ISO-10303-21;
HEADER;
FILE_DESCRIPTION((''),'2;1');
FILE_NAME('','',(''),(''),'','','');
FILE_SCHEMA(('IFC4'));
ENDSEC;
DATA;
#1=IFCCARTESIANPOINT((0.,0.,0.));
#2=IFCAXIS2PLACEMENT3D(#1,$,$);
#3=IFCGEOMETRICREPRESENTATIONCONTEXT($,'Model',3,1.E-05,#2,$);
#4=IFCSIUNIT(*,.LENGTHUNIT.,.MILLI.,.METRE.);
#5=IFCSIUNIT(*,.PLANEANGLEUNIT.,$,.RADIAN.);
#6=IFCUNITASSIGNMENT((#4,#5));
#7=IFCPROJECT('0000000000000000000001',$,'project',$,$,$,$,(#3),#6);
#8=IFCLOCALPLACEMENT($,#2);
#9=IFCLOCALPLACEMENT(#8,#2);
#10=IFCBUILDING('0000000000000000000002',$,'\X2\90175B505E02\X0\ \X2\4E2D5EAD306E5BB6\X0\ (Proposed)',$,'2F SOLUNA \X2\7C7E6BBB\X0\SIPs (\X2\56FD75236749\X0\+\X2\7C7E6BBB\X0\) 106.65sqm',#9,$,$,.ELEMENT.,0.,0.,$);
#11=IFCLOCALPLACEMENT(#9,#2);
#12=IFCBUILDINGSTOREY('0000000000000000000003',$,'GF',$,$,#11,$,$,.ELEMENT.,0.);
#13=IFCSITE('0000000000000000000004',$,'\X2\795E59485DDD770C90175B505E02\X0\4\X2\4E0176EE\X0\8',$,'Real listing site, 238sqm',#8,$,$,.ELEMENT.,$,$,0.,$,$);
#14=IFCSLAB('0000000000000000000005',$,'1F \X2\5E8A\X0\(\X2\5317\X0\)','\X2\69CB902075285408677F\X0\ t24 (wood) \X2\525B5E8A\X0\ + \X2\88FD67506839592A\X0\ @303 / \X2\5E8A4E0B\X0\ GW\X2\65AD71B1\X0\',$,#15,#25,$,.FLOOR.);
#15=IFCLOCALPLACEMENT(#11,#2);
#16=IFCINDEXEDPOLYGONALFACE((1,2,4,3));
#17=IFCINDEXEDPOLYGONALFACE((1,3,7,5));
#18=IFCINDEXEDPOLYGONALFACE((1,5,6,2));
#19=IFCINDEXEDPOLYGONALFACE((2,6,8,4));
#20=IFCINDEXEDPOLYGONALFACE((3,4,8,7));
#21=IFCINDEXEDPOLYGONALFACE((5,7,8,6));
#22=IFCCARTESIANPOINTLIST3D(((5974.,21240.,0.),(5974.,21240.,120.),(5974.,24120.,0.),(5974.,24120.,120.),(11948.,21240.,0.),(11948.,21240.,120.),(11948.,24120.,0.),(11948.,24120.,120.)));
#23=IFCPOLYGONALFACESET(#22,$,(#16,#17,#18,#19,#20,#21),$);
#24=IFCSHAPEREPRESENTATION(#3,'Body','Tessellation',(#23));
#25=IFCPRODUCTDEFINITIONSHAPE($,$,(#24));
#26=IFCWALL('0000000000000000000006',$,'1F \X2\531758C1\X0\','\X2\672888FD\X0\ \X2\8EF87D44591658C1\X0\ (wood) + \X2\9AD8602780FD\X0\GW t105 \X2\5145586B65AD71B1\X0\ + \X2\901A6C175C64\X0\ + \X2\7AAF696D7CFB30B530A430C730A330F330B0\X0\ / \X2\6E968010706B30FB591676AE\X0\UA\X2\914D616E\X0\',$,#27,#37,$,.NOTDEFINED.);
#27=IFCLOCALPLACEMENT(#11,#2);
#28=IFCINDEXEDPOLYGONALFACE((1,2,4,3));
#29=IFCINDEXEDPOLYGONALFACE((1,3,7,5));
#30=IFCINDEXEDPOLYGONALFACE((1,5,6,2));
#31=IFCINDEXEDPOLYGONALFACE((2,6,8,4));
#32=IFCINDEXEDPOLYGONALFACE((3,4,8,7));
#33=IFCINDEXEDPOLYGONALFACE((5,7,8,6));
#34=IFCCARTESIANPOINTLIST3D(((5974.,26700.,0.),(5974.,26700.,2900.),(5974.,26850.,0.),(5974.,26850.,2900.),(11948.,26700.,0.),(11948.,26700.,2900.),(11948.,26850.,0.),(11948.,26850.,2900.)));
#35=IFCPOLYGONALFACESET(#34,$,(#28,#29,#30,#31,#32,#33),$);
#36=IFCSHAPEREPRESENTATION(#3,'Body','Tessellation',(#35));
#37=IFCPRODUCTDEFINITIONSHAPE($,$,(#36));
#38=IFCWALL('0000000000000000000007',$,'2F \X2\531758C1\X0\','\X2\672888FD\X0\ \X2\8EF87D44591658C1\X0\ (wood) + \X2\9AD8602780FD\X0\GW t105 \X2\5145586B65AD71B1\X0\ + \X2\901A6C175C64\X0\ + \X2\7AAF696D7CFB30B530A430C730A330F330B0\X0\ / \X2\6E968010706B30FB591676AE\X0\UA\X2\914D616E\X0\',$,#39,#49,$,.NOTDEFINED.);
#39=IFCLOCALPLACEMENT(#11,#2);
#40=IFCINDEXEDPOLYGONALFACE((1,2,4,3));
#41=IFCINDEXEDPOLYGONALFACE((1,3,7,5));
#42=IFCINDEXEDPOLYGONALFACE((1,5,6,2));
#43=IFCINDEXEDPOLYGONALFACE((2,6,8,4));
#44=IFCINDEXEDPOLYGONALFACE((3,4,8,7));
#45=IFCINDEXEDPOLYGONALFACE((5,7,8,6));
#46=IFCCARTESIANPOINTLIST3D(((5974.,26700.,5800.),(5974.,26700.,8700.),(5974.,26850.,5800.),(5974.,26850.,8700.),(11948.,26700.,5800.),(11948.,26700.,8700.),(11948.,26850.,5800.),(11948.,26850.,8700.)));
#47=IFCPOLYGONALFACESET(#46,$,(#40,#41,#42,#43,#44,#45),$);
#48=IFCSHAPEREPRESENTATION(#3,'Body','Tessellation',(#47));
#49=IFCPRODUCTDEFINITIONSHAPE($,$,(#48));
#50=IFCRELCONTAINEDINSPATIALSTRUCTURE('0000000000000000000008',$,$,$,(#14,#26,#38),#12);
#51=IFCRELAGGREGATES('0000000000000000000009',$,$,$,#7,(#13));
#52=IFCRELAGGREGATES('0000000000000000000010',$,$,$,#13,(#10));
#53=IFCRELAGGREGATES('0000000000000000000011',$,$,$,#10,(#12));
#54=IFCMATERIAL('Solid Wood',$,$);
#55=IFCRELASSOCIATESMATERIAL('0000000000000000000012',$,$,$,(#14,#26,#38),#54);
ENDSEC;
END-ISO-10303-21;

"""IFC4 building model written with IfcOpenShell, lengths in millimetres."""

from ifc_helpers import new_model, si_unit, frame, frame_2d, origin, place, context, project, spatial, rectangle, extrude, material, element, save


model = new_model("IFC4")

# Units and contexts
model_context = context("Model", 3, precision=1e-05, world=origin())
ifc_project = project(units=[si_unit("LENGTHUNIT", "METRE", prefix="MILLI"), si_unit("PLANEANGLEUNIT", "RADIAN")], contexts=[model_context])

# Site, building, storey
site_placement = place(None, origin())
site = spatial("IfcSite", under=ifc_project, at=site_placement, Name="神奈川県逗子市4丁目8", ObjectType="Real listing site, 238sqm", CompositionType="ELEMENT", RefElevation=0.0)
building_placement = place(site_placement, origin())
building = spatial("IfcBuilding", under=site, at=building_placement, Name="逗子市 中庭の家 (Proposed)", ObjectType="2F SOLUNA 籾殻SIPs (国産杉+籾殻) 106.65sqm", CompositionType="ELEMENT", ElevationOfRefHeight=0.0, ElevationOfTerrain=0.0)
storey_placement = place(building_placement, origin())
storey = spatial("IfcBuildingStorey", under=building, at=storey_placement, Name="GF", CompositionType="ELEMENT", Elevation=0.0)

# Slab
ifc_material_1 = material(Name="Solid Wood")
slab_1_placement = place(storey_placement, frame((2987.0, 10620.0, 0.0)))
element("IfcSlab", 1, at=slab_1_placement, inside=storey, material=ifc_material_1, Name="1F 床(北)", Description="構造用合板 t24 (wood) 剛床 + 製材根太 @303 / 床下 GW断熱", PredefinedType="FLOOR", context=model_context, shape_type="SweptSolid", body=[
    extrude(rectangle(XDim=5974.0, YDim=2880.0, at=frame_2d((2987.0, 1440.0))), frame((2987.0, 10620.0, 0.0)), (0.0, 0.0, 1.0), 120.0),
])

# Wall
wall_1_placement = place(storey_placement, frame((2987.0, 13350.0, 0.0)))
element("IfcWall", 2, at=wall_1_placement, inside=storey, material=ifc_material_1, Name="1F 北壁", Description="木製 軸組外壁 (wood) + 高性能GW t105 充填断熱 + 通気層 + 窯業系サイディング / 準耐火・外皮UA配慮", PredefinedType="NOTDEFINED", context=model_context, shape_type="SweptSolid", body=[
    extrude(rectangle(XDim=5974.0, YDim=150.0, at=frame_2d((2987.0, 75.0))), frame((2987.0, 13350.0, 0.0)), (0.0, 0.0, 1.0), 2900.0),
])

# Wall
wall_2_placement = place(storey_placement, frame((2987.0, 13350.0, 2900.0)))
element("IfcWall", 3, at=wall_2_placement, inside=storey, material=ifc_material_1, Name="2F 北壁", Description="木製 軸組外壁 (wood) + 高性能GW t105 充填断熱 + 通気層 + 窯業系サイディング / 準耐火・外皮UA配慮", PredefinedType="NOTDEFINED", context=model_context, shape_type="SweptSolid", body=[
    extrude(rectangle(XDim=5974.0, YDim=150.0, at=frame_2d((2987.0, 75.0))), frame((2987.0, 13350.0, 2900.0)), (0.0, 0.0, 1.0), 2900.0),
])

save(model, "model.ifc")
